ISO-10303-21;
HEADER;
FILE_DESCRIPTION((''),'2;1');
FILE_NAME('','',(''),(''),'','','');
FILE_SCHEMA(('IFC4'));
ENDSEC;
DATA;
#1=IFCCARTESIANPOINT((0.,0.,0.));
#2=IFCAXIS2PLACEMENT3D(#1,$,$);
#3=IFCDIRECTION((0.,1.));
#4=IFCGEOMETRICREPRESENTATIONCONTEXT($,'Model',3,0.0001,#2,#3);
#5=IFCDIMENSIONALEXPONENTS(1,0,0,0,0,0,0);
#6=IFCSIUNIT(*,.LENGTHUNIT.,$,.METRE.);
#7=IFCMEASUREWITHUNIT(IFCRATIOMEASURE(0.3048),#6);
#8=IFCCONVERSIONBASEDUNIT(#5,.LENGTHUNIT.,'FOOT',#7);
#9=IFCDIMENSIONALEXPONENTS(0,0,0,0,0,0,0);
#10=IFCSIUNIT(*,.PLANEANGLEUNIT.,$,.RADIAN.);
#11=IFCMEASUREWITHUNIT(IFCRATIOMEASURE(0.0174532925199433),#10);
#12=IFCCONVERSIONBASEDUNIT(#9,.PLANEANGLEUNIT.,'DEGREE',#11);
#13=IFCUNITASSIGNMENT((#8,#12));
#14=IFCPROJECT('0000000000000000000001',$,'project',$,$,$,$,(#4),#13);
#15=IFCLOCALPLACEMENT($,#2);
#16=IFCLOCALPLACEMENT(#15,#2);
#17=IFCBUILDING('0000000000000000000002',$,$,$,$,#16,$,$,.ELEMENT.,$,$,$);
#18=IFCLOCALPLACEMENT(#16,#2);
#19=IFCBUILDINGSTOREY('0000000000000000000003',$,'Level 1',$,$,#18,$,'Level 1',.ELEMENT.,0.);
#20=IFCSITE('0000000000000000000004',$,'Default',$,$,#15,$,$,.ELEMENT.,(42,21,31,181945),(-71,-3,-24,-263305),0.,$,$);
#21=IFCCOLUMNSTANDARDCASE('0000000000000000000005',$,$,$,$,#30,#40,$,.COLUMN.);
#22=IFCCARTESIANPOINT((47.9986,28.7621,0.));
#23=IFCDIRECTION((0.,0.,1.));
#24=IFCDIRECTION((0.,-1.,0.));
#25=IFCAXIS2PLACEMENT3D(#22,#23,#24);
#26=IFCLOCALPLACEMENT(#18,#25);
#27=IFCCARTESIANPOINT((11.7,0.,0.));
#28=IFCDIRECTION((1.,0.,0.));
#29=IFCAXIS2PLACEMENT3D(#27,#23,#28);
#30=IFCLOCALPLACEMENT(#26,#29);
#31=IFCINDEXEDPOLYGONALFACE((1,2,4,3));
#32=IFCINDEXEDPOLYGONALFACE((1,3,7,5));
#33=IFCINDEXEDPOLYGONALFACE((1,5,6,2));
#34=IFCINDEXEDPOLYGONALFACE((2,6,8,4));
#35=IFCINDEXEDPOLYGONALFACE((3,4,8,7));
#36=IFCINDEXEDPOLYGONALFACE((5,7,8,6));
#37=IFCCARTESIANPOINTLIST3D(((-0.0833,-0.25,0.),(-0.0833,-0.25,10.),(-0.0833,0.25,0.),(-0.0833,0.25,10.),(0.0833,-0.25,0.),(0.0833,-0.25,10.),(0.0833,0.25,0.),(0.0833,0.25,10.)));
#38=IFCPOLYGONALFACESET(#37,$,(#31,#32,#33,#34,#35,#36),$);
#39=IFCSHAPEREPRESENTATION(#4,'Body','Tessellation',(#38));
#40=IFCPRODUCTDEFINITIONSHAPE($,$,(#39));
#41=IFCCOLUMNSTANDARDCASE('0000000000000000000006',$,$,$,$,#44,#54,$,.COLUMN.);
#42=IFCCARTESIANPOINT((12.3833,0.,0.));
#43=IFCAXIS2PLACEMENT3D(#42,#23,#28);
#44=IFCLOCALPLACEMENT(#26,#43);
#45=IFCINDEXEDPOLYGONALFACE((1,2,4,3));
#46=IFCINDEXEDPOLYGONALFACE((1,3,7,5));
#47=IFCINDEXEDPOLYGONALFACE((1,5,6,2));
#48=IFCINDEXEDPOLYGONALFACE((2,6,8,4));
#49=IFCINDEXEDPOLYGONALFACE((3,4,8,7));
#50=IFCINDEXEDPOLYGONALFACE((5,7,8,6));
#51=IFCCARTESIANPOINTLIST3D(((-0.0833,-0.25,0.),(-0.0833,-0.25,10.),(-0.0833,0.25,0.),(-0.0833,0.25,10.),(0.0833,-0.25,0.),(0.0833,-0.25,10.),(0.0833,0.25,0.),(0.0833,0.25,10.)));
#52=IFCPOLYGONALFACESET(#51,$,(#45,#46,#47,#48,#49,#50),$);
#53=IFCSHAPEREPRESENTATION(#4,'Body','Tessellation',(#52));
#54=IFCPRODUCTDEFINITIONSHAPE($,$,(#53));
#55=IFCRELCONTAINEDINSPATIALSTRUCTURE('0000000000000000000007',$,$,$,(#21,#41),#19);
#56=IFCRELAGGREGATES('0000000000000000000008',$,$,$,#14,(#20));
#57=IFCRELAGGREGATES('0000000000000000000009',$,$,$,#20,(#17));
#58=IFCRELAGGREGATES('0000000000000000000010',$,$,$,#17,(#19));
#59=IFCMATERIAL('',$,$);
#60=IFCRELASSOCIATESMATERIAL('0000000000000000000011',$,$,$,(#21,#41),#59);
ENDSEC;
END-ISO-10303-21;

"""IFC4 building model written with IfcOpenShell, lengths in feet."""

from ifc_helpers import new_model, entity, si_unit, converted_unit, direction, frame, origin, place, context, project, spatial, rectangle, extrude, material, element, save


model = new_model("IFC4")

# Units and contexts
model_context = context("Model", 3, precision=0.0001, world=origin(), true_north=direction((0.0, 1.0)))
ifc_project = project(units=[converted_unit("LENGTHUNIT", "FOOT", entity("IfcRatioMeasure", 0.3048), si_unit("LENGTHUNIT", "METRE"), dimensions=[1, 0, 0, 0, 0, 0, 0]), converted_unit("PLANEANGLEUNIT", "DEGREE", entity("IfcRatioMeasure", 0.0174532925199433), si_unit("PLANEANGLEUNIT", "RADIAN"), dimensions=[0, 0, 0, 0, 0, 0, 0])], contexts=[model_context])

# Site, building, storey
site_placement = place(None, origin())
site = spatial("IfcSite", under=ifc_project, at=site_placement, Name="Default", CompositionType="ELEMENT", RefLatitude=(42, 21, 31, 181945), RefLongitude=(-71, -3, -24, -263305), RefElevation=0.0)
building_placement = place(site_placement, origin())
building = spatial("IfcBuilding", under=site, at=building_placement, CompositionType="ELEMENT")
storey_placement = place(building_placement, origin())
storey = spatial("IfcBuildingStorey", under=building, at=storey_placement, Name="Level 1", LongName="Level 1", CompositionType="ELEMENT", Elevation=0.0)

# Columns
ifc_material_1 = material(Name="")
wall_placement = place(storey_placement, frame((47.9986, 28.7621, 0.0), z_axis=(0.0, 0.0, 1.0), x_axis=(0.0, -1.0, 0.0)))
for number, where, z_axis, x_axis in (
    (1, (11.7, 0.0, 0.0), (0.0, 0.0, 1.0), (1.0, 0.0, 0.0)),
    (2, (12.3833, 0.0, 0.0), (0.0, 0.0, 1.0), (1.0, 0.0, 0.0)),
):
    element("IfcColumnStandardCase", number, at=place(wall_placement, frame(where, z_axis=z_axis, x_axis=x_axis)), inside=storey, material=ifc_material_1, PredefinedType="COLUMN", context=model_context, shape_type="SweptSolid", body=[
        extrude(rectangle(XDim=0.1667, YDim=0.5), origin(), (0.0, 0.0, 1.0), 10.0),
    ])

save(model, "model.ifc")
